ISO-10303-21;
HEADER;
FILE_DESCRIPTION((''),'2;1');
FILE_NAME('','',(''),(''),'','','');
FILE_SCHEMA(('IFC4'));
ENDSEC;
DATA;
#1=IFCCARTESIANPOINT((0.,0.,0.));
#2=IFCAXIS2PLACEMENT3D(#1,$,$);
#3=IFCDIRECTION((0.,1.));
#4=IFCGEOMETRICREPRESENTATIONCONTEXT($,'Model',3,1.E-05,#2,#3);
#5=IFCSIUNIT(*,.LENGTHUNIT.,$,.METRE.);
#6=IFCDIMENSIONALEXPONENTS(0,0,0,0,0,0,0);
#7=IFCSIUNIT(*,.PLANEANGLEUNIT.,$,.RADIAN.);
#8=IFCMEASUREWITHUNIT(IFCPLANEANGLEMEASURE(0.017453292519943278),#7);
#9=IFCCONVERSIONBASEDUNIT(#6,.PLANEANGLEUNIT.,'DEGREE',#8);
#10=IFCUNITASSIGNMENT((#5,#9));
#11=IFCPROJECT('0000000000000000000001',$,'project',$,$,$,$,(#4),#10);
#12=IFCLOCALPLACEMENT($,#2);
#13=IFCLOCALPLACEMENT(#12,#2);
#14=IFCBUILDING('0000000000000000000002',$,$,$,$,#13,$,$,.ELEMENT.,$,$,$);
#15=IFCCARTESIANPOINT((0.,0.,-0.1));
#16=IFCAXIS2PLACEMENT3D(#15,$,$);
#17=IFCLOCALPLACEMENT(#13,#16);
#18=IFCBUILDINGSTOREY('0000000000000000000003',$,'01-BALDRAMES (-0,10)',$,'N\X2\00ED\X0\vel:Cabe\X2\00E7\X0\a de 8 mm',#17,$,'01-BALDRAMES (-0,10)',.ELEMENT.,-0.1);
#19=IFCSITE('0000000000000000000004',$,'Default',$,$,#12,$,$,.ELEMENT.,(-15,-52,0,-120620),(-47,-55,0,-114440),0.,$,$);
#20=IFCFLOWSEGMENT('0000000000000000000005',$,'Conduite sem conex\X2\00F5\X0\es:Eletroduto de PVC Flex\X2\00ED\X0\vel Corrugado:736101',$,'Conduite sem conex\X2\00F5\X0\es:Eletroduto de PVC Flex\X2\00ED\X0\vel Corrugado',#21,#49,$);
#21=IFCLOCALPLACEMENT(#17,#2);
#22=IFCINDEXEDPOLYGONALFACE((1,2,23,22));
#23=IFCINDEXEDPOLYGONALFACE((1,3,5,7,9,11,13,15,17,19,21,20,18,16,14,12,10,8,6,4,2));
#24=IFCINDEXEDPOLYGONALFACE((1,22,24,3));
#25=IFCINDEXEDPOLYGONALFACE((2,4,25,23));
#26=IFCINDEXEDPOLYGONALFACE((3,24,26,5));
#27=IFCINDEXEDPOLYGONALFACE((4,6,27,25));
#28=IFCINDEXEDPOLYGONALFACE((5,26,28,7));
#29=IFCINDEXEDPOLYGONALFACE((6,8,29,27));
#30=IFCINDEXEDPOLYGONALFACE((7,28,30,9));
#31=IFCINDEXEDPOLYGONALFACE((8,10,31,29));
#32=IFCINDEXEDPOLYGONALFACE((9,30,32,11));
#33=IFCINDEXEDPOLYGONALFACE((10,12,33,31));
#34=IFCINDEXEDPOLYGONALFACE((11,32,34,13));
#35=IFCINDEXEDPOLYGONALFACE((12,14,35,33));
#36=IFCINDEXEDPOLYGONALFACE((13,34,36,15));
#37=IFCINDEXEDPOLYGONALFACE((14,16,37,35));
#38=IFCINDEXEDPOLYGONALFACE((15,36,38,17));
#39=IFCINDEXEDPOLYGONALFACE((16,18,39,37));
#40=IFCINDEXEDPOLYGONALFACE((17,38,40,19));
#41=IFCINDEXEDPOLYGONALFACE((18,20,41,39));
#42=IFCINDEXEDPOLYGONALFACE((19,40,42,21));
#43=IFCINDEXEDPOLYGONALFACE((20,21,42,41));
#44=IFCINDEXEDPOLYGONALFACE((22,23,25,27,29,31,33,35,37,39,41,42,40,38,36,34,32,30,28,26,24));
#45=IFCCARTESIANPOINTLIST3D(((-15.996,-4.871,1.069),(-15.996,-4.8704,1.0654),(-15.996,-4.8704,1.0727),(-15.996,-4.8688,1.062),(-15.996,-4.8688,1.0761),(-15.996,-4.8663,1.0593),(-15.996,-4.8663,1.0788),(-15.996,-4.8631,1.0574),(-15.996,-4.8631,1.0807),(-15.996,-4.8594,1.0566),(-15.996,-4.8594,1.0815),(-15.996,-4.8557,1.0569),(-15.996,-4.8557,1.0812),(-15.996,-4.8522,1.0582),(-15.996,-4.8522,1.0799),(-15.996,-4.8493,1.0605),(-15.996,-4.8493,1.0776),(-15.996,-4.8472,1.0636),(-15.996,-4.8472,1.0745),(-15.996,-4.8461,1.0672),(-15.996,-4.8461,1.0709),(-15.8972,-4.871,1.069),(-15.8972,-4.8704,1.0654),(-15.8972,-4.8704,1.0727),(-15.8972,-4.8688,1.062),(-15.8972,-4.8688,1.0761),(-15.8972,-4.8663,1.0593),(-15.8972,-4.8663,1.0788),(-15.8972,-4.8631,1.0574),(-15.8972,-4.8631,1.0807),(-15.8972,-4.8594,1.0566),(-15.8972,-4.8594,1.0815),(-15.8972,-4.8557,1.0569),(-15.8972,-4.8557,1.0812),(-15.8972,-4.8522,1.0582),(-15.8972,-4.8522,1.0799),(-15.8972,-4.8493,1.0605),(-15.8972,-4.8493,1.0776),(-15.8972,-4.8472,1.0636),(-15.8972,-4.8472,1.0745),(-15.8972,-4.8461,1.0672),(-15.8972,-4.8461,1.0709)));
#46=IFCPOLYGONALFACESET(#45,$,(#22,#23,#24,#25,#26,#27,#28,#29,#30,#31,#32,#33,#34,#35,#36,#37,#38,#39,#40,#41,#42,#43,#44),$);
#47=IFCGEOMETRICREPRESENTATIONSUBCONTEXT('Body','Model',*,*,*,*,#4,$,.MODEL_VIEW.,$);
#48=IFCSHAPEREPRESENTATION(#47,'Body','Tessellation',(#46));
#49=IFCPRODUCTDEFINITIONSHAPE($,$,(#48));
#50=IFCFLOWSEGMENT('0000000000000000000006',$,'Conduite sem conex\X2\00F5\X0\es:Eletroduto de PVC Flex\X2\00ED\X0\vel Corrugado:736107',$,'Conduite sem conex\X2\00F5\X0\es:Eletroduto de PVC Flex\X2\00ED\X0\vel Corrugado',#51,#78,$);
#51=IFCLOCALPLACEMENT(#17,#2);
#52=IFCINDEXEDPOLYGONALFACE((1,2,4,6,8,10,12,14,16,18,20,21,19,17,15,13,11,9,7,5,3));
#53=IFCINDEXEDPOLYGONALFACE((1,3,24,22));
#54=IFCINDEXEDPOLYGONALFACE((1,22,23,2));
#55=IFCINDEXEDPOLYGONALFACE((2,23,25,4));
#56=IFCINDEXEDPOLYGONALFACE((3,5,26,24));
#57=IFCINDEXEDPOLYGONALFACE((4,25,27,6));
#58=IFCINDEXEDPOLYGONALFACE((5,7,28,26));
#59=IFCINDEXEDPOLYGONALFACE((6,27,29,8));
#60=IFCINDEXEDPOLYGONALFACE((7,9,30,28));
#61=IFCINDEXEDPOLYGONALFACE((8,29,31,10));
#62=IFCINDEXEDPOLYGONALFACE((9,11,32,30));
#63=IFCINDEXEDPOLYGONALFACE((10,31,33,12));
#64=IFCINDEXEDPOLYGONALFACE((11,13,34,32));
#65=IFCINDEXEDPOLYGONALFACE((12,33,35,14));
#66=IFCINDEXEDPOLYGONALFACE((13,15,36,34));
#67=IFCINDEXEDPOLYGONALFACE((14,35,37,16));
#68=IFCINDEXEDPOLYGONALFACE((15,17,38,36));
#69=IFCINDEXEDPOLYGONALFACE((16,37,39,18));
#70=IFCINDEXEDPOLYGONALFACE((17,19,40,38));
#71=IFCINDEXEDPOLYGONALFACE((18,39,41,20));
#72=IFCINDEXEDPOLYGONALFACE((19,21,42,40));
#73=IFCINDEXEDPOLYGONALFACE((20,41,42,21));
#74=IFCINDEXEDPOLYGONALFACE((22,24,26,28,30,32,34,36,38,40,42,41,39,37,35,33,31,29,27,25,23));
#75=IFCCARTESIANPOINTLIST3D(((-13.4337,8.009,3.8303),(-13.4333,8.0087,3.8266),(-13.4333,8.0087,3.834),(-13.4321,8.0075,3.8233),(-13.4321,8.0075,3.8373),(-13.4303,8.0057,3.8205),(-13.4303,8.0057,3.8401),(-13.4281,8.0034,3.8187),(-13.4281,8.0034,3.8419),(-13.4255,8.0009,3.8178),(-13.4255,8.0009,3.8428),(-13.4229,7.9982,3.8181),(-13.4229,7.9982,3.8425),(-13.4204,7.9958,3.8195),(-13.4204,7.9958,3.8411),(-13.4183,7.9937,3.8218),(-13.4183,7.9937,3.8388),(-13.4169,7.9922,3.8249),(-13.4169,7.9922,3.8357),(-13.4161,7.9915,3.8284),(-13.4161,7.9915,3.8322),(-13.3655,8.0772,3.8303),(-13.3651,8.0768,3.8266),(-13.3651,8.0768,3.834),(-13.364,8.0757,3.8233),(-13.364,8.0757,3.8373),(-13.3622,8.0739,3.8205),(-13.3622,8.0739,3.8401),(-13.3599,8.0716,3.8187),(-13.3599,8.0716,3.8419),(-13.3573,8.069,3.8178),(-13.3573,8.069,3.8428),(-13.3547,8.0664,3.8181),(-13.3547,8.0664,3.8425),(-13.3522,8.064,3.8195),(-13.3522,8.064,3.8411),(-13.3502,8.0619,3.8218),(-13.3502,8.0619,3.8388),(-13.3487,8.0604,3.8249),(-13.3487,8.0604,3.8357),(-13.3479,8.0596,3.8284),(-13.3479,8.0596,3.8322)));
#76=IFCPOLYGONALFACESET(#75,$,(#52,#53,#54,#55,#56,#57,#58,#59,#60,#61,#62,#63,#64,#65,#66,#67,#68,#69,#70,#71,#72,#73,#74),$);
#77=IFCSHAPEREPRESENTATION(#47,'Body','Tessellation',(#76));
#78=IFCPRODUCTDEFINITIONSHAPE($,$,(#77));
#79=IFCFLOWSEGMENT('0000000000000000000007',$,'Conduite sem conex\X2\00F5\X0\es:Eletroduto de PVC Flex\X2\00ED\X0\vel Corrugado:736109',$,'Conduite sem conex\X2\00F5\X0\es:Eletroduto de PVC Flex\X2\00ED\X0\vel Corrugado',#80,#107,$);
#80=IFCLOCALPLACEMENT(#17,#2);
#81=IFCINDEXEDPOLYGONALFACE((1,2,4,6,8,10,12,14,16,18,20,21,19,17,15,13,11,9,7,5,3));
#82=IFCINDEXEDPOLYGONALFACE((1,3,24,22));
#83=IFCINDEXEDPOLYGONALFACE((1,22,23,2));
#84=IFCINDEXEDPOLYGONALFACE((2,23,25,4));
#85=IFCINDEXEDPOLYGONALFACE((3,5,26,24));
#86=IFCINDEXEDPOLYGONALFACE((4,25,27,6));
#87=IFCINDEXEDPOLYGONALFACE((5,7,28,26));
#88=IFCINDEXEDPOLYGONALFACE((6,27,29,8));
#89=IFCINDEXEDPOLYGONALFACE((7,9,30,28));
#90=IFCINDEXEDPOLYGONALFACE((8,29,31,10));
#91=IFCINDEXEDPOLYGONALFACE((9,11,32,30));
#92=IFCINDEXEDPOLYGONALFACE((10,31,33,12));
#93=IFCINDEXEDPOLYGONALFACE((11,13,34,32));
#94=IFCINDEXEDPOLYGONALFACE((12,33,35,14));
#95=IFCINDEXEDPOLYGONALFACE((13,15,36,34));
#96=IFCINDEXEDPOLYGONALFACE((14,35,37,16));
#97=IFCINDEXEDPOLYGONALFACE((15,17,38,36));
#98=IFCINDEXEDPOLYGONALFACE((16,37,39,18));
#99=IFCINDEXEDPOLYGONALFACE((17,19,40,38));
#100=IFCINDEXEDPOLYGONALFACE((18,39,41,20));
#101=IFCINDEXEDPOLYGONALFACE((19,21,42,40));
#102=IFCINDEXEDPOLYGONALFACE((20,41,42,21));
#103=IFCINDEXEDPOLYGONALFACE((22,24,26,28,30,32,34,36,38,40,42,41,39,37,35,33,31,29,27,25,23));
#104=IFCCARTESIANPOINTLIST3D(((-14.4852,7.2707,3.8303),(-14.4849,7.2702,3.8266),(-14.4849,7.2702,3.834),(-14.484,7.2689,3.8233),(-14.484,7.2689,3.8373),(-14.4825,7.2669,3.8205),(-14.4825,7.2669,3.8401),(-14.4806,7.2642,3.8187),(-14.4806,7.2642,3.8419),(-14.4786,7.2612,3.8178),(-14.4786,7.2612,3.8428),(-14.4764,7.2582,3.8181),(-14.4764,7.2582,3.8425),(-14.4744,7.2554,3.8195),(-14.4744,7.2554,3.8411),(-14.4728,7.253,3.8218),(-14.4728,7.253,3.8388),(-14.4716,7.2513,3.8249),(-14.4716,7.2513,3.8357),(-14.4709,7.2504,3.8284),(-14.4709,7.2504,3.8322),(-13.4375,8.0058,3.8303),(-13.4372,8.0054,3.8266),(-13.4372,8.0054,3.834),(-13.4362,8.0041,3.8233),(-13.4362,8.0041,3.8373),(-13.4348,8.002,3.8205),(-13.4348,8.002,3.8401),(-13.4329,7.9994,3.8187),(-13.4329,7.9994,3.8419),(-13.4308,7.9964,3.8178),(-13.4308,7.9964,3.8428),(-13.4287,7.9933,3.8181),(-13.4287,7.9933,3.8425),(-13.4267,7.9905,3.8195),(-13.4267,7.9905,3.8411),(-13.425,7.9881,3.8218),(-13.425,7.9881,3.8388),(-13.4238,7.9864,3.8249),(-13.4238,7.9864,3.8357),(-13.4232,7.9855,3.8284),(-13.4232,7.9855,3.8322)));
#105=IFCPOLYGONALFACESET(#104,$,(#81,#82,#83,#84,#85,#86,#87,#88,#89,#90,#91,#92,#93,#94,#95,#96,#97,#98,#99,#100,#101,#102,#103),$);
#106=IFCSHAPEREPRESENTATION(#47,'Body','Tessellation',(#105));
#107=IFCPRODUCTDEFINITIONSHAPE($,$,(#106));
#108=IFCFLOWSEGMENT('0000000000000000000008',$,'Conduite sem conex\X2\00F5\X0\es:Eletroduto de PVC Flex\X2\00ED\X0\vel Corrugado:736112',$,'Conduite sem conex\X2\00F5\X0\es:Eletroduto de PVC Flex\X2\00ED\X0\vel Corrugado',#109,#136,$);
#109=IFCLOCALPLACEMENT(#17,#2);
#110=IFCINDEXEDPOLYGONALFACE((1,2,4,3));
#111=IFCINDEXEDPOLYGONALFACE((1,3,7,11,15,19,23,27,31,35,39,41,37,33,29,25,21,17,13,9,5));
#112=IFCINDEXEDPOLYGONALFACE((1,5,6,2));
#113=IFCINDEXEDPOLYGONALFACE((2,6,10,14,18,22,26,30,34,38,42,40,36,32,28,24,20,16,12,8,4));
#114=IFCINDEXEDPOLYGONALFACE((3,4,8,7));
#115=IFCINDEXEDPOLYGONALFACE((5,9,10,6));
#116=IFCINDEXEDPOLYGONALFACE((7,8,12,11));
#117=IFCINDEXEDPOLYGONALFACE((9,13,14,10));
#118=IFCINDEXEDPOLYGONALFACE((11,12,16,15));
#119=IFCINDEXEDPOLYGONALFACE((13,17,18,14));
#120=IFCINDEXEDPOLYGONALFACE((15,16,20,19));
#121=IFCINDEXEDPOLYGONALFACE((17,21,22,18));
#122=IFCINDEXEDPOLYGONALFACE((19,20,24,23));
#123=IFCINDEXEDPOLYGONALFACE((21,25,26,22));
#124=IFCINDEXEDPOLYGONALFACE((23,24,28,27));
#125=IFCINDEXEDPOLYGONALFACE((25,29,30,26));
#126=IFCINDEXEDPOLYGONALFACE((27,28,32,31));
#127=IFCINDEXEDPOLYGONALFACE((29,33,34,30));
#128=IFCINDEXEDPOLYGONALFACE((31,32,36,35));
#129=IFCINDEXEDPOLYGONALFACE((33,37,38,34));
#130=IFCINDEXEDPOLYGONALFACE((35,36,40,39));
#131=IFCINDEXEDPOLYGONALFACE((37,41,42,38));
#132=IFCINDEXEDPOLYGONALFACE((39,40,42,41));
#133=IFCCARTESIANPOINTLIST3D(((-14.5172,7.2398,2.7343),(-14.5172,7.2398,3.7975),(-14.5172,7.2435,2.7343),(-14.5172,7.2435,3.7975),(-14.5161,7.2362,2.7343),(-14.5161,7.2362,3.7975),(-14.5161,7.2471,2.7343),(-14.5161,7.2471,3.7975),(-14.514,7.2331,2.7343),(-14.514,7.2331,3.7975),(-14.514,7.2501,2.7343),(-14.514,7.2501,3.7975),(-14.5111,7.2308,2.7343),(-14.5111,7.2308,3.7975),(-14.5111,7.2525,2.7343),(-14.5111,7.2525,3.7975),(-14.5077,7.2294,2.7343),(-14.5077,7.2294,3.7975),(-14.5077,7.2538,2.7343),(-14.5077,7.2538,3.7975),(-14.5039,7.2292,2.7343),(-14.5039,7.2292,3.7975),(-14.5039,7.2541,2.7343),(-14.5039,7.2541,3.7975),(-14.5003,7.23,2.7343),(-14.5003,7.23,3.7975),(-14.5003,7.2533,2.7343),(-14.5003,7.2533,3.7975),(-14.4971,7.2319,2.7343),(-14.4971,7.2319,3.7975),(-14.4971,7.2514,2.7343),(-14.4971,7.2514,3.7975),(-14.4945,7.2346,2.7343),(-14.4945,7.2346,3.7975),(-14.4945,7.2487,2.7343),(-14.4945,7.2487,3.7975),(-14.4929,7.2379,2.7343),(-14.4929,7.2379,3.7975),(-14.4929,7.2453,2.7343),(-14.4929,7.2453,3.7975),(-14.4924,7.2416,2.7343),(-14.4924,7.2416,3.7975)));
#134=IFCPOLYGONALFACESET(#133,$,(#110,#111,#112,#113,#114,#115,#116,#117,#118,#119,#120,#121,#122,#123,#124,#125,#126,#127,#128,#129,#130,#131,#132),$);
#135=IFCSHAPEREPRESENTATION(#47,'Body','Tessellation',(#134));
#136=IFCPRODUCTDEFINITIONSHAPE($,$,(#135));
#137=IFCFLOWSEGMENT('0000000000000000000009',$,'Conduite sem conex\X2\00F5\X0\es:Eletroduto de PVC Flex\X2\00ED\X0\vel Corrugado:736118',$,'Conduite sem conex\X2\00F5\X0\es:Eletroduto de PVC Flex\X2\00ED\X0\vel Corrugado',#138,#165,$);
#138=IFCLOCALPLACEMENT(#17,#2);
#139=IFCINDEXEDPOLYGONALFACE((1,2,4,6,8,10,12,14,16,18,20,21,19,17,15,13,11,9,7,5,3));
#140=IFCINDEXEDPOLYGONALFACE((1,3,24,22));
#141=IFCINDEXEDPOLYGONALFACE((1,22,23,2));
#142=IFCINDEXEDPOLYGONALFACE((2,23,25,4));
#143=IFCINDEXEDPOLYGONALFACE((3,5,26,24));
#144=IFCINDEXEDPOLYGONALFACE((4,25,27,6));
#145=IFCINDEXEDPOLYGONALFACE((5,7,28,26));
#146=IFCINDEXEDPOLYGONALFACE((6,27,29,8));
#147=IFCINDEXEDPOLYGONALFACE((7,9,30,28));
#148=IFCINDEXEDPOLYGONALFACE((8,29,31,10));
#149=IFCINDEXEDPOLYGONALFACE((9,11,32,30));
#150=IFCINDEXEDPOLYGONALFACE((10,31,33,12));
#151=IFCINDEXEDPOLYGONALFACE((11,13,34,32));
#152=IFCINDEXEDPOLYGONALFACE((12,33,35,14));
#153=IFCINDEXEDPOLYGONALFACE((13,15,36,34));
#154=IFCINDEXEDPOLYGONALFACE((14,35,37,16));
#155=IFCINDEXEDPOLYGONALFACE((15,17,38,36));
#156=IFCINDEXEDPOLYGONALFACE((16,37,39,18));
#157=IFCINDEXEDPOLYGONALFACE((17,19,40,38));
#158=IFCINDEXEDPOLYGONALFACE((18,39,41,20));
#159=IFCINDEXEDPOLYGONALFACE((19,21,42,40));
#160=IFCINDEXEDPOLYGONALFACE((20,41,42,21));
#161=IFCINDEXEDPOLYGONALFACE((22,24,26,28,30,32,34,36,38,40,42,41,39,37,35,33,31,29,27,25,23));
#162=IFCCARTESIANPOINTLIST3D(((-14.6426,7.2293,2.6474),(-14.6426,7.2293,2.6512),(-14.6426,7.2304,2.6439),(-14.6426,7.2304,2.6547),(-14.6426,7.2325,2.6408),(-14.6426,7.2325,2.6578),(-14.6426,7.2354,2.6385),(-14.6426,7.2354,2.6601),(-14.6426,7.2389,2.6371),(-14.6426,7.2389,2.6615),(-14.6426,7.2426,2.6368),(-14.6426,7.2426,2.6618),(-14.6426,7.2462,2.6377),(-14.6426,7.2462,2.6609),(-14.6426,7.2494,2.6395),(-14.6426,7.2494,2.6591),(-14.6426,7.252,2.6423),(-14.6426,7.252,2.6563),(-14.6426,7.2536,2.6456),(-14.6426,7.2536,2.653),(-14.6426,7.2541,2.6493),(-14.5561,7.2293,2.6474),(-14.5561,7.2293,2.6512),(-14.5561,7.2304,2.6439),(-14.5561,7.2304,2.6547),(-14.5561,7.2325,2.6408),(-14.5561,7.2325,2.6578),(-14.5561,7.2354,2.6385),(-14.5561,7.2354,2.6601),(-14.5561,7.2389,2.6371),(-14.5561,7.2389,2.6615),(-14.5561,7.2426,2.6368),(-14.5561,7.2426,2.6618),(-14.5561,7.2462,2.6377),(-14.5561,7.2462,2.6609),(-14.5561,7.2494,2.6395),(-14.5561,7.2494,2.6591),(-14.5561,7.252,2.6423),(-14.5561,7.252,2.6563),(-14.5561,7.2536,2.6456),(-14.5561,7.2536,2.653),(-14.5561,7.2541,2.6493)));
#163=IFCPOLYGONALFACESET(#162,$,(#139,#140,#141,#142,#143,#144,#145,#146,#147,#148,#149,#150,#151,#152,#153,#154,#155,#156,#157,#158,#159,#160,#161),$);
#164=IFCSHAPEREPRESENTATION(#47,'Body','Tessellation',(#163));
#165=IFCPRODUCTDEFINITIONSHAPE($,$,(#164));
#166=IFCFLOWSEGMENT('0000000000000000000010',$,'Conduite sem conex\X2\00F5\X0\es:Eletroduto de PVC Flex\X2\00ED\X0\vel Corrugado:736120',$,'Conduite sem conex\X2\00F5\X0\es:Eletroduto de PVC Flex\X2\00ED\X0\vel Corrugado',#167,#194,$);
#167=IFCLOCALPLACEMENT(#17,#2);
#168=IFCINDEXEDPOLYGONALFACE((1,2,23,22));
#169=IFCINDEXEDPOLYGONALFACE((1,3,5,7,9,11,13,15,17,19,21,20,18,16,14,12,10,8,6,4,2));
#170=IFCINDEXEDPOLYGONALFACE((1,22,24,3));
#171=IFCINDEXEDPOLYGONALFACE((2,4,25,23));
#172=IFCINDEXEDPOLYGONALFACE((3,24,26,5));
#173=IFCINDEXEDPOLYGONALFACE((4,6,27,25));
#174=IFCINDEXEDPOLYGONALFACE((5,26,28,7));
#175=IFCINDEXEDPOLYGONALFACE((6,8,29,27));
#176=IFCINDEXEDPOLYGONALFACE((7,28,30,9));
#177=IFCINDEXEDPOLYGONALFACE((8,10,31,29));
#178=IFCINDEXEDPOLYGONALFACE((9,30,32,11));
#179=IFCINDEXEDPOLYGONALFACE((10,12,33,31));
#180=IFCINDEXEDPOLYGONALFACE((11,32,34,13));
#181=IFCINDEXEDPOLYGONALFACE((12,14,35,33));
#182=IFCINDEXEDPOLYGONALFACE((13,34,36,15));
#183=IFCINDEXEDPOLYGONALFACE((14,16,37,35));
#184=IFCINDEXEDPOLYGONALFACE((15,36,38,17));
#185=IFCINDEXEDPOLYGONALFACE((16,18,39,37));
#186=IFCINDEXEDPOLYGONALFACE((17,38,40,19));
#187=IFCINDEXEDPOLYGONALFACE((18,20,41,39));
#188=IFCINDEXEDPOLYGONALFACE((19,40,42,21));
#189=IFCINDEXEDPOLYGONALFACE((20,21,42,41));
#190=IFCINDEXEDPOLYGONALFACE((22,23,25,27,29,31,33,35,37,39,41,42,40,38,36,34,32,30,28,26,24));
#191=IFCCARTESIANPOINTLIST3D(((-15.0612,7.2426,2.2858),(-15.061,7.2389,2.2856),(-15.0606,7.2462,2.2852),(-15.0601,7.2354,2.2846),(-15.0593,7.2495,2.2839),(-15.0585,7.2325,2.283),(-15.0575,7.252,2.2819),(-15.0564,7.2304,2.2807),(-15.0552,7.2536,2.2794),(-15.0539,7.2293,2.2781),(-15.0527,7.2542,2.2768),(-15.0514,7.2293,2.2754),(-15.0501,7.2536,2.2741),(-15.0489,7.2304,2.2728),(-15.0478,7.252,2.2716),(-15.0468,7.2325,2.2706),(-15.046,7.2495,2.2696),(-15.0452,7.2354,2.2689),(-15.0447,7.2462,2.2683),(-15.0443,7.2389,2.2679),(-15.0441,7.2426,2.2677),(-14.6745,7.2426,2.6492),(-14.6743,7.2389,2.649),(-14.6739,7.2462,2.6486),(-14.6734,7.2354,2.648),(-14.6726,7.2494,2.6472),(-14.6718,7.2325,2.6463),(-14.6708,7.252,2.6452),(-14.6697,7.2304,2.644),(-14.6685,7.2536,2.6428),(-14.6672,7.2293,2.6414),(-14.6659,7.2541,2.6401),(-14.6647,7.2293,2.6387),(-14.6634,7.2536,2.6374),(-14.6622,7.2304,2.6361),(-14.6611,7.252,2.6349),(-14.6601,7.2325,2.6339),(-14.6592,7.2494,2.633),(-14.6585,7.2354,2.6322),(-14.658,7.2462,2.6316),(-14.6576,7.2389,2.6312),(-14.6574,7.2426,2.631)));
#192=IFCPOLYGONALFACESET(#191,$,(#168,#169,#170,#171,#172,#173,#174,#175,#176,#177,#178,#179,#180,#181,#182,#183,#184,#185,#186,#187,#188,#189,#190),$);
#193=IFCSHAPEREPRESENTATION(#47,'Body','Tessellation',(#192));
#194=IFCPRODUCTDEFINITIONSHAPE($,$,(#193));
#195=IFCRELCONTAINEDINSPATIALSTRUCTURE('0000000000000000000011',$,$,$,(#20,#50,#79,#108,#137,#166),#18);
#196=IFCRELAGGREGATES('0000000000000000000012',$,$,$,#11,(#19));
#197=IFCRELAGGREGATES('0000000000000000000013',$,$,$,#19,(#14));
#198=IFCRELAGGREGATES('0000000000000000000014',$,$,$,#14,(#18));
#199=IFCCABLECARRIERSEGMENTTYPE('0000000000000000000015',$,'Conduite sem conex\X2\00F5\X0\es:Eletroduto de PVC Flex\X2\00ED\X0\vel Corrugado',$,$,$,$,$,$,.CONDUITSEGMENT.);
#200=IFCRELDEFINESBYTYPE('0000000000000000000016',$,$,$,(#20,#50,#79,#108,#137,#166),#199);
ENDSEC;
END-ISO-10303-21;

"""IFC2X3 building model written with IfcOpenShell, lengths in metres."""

from ifc_helpers import new_model, entity, si_unit, converted_unit, direction, frame, frame_2d, origin, origin_2d_with_axis, place, context, subcontext, project, spatial, circle, extrude, type_object, element, save


model = new_model("IFC2X3")

# Units and contexts
model_context = context("Model", 3, precision=1e-05, world=origin(), true_north=direction((0.0, 1.0)))
body_context = subcontext(model_context, "Body", "Model", "MODEL_VIEW")
ifc_project = project(units=[si_unit("LENGTHUNIT", "METRE"), converted_unit("PLANEANGLEUNIT", "DEGREE", entity("IfcPlaneAngleMeasure", 0.017453292519943278), si_unit("PLANEANGLEUNIT", "RADIAN"), dimensions=[0, 0, 0, 0, 0, 0, 0])], contexts=[model_context])

# Site, building, storey
site_placement = place(None, origin())
site = spatial("IfcSite", under=ifc_project, at=site_placement, Name="Default", CompositionType="ELEMENT", RefLatitude=(-15, -52, 0, -120620), RefLongitude=(-47, -55, 0, -114440), RefElevation=0.0)
building_placement = place(site_placement, origin())
building = spatial("IfcBuilding", under=site, at=building_placement, CompositionType="ELEMENT")
storey_placement = place(building_placement, frame((0.0, 0.0, -0.1)))
storey = spatial("IfcBuildingStorey", under=building, at=storey_placement, Name="01-BALDRAMES (-0,10)", ObjectType="Nível:Cabeça de 8 mm", LongName="01-BALDRAMES (-0,10)", CompositionType="ELEMENT", Elevation=-0.1)

# Flow segments
cable_carrier_segment_type = type_object("IfcCableCarrierSegmentType", Name="Conduite sem conexões:Eletroduto de PVC Flexível Corrugado", PredefinedType="CONDUITSEGMENT")
flow_segment_1_placement = place(storey_placement, origin())
element("IfcFlowSegment", 1, at=flow_segment_1_placement, inside=storey, type_object=cable_carrier_segment_type, Name="Conduite sem conexões:Eletroduto de PVC Flexível Corrugado:736101", ObjectType="Conduite sem conexões:Eletroduto de PVC Flexível Corrugado", context=body_context, shape_type="SweptSolid", body=[
    extrude(circle(Radius=0.0125, at=origin_2d_with_axis()), frame((-15.996, -4.8585, 1.069), z_axis=(1.0, -0.000002, 0.0), x_axis=(-0.000002, -1.0, 0.0)), (0.0, 0.0, 1.0), 0.0988),
])
flow_segment_2_placement = place(storey_placement, origin())
element("IfcFlowSegment", 2, at=flow_segment_2_placement, inside=storey, type_object=cable_carrier_segment_type, Name="Conduite sem conexões:Eletroduto de PVC Flexível Corrugado:736107", ObjectType="Conduite sem conexões:Eletroduto de PVC Flexível Corrugado", context=body_context, shape_type="SweptSolid", body=[
    extrude(circle(Radius=0.0125, at=frame_2d((0.0, 0.0), x_axis=(1.0, 0.0))), frame((-13.4248, 8.0002, 3.8303), z_axis=(0.707107, 0.707107, 0.0), x_axis=(-0.707107, 0.707107, 0.0)), (0.0, 0.0, 1.0), 0.0964),
])
flow_segment_3_placement = place(storey_placement, origin())
element("IfcFlowSegment", 3, at=flow_segment_3_placement, inside=storey, type_object=cable_carrier_segment_type, Name="Conduite sem conexões:Eletroduto de PVC Flexível Corrugado:736109", ObjectType="Conduite sem conexões:Eletroduto de PVC Flexível Corrugado", context=body_context, shape_type="SweptSolid", body=[
    extrude(circle(Radius=0.0125, at=frame_2d((0.0, 0.0), x_axis=(1.0, 0.0))), frame((-14.478, 7.2605, 3.8303), z_axis=(0.818595, 0.574371, 0.0), x_axis=(-0.574371, 0.818595, 0.0)), (0.0, 0.0, 1.0), 1.2799),
])
flow_segment_4_placement = place(storey_placement, origin())
element("IfcFlowSegment", 4, at=flow_segment_4_placement, inside=storey, type_object=cable_carrier_segment_type, Name="Conduite sem conexões:Eletroduto de PVC Flexível Corrugado:736112", ObjectType="Conduite sem conexões:Eletroduto de PVC Flexível Corrugado", context=body_context, shape_type="SweptSolid", body=[
    extrude(circle(Radius=0.0125, at=frame_2d((0.0, 0.0), x_axis=(1.0, 0.0))), frame((-14.5049, 7.2416, 2.7343)), (0.0, 0.0, 1.0), 1.0632),
])
flow_segment_5_placement = place(storey_placement, origin())
element("IfcFlowSegment", 5, at=flow_segment_5_placement, inside=storey, type_object=cable_carrier_segment_type, Name="Conduite sem conexões:Eletroduto de PVC Flexível Corrugado:736118", ObjectType="Conduite sem conexões:Eletroduto de PVC Flexível Corrugado", context=body_context, shape_type="SweptSolid", body=[
    extrude(circle(Radius=0.0125, at=frame_2d((0.0, 0.0), x_axis=(1.0, 0.0))), frame((-14.6426, 7.2416, 2.6493), z_axis=(1.0, -0.000086, 0.0), x_axis=(0.000086, 1.0, 0.0)), (0.0, 0.0, 1.0), 0.0865),
])
flow_segment_6_placement = place(storey_placement, origin())
element("IfcFlowSegment", 6, at=flow_segment_6_placement, inside=storey, type_object=cable_carrier_segment_type, Name="Conduite sem conexões:Eletroduto de PVC Flexível Corrugado:736120", ObjectType="Conduite sem conexões:Eletroduto de PVC Flexível Corrugado", context=body_context, shape_type="SweptSolid", body=[
    extrude(circle(Radius=0.0125, at=origin_2d_with_axis()), frame((-14.6659, 7.2416, 2.6401), z_axis=(-0.728811, 0.000063, -0.684715), x_axis=(0.000086, 1.0, 0.0)), (0.0, 0.0, 1.0), 0.5306),
])

save(model, "model.ifc")
